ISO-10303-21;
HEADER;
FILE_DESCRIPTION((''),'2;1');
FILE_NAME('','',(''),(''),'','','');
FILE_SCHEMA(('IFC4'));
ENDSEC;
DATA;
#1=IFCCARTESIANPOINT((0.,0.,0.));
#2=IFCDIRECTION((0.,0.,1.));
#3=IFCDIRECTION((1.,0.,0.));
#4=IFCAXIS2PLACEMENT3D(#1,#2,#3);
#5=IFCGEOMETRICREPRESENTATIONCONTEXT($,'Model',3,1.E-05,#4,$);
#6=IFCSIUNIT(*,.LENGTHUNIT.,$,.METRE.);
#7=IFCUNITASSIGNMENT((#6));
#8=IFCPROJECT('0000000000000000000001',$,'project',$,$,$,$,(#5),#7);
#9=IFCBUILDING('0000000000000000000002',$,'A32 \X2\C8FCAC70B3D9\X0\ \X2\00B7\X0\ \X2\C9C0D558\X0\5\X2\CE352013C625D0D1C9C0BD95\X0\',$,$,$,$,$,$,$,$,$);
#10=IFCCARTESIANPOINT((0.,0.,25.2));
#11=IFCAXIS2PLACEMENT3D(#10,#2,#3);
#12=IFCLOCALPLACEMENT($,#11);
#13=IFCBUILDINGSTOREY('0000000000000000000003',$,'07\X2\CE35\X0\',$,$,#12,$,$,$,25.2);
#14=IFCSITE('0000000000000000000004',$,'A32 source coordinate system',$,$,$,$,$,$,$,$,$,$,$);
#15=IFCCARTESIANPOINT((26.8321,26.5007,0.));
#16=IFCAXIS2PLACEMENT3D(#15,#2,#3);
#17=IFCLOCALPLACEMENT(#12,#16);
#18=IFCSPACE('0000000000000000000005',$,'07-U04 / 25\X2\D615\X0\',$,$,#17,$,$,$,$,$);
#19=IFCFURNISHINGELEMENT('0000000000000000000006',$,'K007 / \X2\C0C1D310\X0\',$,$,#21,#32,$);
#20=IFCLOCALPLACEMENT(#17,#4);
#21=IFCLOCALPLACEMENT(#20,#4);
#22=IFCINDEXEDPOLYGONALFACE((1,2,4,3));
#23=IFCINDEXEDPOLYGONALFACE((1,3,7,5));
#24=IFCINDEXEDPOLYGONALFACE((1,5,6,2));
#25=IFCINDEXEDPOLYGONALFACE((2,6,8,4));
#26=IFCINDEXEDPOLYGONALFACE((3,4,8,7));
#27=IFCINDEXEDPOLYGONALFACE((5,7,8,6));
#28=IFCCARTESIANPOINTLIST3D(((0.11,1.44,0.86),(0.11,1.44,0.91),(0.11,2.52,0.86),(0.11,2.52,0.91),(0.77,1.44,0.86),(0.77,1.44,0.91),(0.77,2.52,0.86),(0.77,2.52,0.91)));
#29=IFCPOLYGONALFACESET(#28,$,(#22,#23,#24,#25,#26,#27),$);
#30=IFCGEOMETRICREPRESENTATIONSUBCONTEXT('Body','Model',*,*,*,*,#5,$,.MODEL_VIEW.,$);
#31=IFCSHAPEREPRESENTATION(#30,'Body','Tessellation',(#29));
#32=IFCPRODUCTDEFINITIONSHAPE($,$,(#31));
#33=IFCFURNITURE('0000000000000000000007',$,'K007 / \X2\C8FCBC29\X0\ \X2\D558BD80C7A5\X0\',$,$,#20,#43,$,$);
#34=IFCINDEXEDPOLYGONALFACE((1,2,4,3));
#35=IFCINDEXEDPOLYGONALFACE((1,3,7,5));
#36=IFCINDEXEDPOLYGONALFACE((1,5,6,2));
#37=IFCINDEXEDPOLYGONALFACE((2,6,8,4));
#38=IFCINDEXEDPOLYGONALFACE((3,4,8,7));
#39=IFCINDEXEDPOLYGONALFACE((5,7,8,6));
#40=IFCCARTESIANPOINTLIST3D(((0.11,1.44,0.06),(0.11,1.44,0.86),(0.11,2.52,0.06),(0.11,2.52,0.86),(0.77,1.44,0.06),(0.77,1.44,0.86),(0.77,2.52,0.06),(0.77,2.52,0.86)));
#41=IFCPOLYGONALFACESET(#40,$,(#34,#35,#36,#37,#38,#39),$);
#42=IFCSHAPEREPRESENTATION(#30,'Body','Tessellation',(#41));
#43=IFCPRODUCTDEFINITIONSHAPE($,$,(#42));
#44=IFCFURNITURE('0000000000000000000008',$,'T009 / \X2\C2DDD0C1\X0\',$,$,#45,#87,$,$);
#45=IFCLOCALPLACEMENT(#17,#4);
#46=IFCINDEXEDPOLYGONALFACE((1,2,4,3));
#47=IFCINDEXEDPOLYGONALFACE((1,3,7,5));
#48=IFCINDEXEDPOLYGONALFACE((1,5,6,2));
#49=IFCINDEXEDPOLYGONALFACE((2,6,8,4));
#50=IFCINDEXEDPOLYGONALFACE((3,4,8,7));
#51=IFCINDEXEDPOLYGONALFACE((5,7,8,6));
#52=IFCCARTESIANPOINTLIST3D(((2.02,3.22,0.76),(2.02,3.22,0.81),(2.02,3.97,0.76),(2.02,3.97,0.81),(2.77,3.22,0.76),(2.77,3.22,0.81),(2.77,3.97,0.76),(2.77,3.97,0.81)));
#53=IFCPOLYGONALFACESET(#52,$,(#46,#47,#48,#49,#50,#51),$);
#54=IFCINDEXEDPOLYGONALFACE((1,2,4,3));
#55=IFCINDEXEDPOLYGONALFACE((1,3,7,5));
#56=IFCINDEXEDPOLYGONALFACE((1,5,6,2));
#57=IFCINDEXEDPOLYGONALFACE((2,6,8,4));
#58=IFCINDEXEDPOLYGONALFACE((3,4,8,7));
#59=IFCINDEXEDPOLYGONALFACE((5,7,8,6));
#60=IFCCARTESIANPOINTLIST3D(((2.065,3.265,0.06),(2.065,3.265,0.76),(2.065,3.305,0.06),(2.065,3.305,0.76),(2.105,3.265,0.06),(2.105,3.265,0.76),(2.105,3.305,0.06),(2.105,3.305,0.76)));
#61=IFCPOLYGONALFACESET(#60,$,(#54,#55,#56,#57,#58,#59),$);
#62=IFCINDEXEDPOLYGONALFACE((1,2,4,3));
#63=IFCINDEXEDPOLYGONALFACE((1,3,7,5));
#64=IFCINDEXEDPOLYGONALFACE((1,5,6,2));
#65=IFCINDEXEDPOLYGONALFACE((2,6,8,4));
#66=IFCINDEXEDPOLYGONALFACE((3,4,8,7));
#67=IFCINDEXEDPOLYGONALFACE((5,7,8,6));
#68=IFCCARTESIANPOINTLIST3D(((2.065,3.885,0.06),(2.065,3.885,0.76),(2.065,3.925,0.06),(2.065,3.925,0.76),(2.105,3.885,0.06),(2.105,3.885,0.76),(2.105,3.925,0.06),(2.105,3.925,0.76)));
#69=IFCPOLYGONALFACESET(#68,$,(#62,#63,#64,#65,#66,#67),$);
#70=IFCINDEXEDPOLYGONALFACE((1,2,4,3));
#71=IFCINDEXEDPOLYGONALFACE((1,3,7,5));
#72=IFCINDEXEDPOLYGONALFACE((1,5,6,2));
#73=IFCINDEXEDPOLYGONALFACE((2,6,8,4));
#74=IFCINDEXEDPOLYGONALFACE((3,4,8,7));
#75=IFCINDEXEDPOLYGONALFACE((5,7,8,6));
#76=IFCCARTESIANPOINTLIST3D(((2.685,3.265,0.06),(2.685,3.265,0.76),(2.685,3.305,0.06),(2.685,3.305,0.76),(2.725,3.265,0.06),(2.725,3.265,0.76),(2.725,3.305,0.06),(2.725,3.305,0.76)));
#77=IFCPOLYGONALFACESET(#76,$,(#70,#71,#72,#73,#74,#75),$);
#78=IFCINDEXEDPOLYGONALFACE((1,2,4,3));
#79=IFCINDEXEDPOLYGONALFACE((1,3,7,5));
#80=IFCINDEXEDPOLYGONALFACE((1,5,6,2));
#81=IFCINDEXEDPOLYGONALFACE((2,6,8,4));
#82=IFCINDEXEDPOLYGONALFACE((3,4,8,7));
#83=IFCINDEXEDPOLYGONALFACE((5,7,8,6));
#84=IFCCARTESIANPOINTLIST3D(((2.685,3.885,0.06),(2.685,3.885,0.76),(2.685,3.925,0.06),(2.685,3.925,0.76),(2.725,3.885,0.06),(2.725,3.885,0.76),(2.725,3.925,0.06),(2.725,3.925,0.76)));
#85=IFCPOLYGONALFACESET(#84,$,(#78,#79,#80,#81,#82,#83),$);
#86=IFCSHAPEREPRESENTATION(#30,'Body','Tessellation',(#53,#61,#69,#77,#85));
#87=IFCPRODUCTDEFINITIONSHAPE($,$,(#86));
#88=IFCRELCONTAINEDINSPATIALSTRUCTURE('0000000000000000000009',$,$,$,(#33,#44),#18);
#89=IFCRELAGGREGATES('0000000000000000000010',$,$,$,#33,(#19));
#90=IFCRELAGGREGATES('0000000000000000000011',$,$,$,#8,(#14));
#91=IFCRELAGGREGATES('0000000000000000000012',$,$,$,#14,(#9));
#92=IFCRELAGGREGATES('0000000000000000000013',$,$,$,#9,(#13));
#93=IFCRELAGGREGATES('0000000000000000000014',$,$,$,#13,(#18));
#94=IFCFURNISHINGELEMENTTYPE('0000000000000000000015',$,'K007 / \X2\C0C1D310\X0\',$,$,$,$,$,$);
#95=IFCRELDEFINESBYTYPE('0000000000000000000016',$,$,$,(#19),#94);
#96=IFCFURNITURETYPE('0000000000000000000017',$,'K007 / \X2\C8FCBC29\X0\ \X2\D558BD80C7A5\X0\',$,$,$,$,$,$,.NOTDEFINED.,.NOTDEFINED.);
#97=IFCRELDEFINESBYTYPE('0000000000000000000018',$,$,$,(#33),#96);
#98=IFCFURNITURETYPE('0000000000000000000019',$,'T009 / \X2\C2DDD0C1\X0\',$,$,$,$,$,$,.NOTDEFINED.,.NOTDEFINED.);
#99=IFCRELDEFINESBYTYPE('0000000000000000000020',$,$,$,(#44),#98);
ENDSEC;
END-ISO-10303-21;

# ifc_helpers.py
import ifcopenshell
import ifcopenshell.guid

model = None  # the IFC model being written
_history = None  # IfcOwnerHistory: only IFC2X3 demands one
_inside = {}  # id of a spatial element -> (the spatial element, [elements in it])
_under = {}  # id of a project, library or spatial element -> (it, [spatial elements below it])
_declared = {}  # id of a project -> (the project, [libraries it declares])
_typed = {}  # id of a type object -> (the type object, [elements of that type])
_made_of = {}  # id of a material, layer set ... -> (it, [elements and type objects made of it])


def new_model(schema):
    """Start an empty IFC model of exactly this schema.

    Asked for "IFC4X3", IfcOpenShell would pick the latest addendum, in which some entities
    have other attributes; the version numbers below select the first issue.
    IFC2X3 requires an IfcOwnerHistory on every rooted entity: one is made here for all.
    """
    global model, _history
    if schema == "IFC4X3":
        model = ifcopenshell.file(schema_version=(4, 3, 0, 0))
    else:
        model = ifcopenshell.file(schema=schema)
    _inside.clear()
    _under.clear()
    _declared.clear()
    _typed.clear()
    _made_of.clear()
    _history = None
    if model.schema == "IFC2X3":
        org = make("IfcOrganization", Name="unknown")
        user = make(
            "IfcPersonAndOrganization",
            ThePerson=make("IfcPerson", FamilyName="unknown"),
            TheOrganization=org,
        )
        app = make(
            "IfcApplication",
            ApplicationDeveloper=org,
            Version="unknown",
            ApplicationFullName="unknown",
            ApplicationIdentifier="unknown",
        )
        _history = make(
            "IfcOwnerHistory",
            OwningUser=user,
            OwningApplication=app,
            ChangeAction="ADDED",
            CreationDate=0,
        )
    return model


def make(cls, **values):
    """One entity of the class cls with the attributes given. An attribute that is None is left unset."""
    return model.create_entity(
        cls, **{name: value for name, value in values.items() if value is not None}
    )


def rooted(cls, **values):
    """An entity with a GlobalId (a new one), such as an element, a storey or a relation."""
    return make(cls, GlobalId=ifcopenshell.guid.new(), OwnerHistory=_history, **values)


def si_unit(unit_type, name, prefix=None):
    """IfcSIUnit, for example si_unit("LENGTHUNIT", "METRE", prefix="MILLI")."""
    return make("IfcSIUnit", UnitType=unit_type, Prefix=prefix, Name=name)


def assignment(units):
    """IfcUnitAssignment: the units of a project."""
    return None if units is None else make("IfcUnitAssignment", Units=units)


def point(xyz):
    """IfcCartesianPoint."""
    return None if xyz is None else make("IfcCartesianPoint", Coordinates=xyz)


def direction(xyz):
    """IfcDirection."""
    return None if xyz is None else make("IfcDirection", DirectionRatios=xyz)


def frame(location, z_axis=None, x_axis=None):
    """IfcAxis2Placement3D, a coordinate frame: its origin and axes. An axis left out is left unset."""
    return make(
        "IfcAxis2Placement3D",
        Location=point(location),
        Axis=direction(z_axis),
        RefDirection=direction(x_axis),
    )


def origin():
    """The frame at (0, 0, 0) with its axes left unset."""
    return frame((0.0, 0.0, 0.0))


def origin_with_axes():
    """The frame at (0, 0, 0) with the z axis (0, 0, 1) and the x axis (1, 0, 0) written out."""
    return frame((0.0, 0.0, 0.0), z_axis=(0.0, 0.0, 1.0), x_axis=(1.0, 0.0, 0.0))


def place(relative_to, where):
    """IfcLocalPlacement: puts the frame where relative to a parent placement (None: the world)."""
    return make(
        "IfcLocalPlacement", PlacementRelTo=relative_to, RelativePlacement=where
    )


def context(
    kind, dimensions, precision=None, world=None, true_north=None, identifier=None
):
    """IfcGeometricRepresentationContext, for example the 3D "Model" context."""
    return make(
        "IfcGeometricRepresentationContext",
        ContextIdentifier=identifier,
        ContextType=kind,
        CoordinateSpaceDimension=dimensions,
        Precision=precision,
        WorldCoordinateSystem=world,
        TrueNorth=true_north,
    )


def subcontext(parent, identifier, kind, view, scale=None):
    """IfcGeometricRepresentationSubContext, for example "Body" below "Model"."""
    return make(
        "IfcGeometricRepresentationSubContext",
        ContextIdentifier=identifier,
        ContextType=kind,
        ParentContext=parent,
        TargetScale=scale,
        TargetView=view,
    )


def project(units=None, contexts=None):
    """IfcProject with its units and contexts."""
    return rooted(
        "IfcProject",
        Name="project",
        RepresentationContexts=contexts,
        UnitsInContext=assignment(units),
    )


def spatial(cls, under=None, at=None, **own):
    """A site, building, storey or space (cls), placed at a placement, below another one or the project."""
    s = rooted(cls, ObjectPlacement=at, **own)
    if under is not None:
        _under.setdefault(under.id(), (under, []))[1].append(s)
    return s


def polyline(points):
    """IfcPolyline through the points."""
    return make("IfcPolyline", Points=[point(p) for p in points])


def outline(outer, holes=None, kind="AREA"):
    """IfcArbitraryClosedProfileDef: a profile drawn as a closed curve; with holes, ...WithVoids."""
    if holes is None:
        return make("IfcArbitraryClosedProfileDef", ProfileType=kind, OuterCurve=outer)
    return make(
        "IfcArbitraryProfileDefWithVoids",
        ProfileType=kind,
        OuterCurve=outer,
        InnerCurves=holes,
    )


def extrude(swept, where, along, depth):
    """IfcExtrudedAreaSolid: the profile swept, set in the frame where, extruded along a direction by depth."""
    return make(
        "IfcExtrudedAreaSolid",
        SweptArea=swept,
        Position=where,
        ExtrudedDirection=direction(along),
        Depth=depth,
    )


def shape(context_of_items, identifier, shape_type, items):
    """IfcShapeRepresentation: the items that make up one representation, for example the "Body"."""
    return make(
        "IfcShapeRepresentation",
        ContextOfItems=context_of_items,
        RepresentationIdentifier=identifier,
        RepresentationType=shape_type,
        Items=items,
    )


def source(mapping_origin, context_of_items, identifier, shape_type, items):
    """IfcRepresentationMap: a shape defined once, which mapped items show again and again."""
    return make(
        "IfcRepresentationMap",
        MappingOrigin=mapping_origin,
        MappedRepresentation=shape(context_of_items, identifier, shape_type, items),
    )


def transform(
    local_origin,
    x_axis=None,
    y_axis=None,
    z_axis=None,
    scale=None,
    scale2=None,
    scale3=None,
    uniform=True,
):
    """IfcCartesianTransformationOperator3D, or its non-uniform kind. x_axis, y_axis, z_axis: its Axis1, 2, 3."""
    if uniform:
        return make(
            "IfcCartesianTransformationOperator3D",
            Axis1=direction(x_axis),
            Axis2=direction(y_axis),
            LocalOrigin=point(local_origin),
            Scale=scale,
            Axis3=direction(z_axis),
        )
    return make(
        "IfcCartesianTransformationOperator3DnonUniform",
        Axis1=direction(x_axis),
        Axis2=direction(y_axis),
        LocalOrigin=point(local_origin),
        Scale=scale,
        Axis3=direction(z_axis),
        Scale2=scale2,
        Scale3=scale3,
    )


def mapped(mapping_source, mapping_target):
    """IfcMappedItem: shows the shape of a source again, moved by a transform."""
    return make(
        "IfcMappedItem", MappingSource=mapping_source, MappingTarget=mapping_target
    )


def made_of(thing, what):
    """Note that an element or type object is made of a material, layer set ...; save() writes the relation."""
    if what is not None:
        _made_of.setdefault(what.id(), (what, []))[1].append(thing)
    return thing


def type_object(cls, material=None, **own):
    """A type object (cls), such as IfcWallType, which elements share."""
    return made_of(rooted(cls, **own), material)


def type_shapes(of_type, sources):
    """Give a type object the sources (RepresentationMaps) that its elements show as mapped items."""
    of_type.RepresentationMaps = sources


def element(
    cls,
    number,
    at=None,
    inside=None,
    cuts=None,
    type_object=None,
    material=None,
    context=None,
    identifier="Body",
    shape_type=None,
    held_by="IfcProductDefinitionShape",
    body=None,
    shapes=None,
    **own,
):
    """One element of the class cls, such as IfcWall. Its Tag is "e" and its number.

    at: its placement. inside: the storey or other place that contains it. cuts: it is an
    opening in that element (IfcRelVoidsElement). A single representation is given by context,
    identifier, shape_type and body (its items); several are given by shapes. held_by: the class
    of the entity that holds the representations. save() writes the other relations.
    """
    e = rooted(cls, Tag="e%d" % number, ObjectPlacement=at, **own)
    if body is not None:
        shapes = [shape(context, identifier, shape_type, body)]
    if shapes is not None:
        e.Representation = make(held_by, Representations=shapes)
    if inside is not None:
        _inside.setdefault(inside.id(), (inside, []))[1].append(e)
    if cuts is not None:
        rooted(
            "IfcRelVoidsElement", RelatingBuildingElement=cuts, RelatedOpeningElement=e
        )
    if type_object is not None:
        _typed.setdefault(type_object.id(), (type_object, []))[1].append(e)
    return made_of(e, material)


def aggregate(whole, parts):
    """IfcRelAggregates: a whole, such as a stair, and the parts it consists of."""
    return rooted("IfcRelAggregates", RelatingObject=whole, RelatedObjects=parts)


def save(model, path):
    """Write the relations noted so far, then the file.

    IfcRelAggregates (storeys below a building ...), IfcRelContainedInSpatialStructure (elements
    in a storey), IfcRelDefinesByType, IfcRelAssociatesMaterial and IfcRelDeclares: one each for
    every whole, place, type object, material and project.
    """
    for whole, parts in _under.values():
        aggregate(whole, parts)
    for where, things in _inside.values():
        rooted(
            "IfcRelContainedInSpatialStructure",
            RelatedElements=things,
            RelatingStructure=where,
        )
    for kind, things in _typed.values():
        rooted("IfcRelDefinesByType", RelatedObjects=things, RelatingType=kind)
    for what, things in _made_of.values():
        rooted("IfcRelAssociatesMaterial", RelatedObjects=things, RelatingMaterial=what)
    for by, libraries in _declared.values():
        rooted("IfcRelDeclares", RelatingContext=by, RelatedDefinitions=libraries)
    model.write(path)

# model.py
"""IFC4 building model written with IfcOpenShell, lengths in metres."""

from ifc_helpers import new_model, si_unit, frame, origin, origin_with_axes, place, context, subcontext, project, spatial, polyline, outline, extrude, source, transform, mapped, type_object, type_shapes, element, aggregate, save


model = new_model("IFC4")

# Units and contexts
model_context = context("Model", 3, precision=1e-05, world=origin_with_axes())
body_context = subcontext(model_context, "Body", "Model", "MODEL_VIEW")
ifc_project = project(units=[si_unit("LENGTHUNIT", "METRE")], contexts=[model_context])

# Site, building, storey
site = spatial("IfcSite", under=ifc_project, Name="A32 source coordinate system")
building = spatial("IfcBuilding", under=site, Name="A32 주거동 · 지하5층–옥탑지붕")
storey_placement = place(None, frame((0.0, 0.0, 25.2), z_axis=(0.0, 0.0, 1.0), x_axis=(1.0, 0.0, 0.0)))
storey = spatial("IfcBuildingStorey", under=building, at=storey_placement, Name="07층", Elevation=25.2)

# Shared definitions
space_1_placement = place(storey_placement, frame((26.8321, 26.5007, 0.0), z_axis=(0.0, 0.0, 1.0), x_axis=(1.0, 0.0, 0.0)))
space_1 = spatial("IfcSpace", under=storey, at=space_1_placement, Name="07-U04 / 25형")

# Furnishing element
furnishing_element_type_1 = type_object("IfcFurnishingElementType", Name="K007 / 상판")
shared_shape_1 = source(origin(), body_context, "Body", "SweptSolid", [
    extrude(outline(polyline([(0.77, 2.52), (0.77, 1.44), (0.11, 1.44), (0.11, 2.52), (0.77, 2.52)])), frame((0.0, 0.0, 0.86)), (0.0, 0.0, 1.0), 0.05),
])
type_shapes(furnishing_element_type_1, [shared_shape_1])
furniture_1_placement = place(space_1_placement, origin_with_axes())
furnishing_1_placement = place(furniture_1_placement, origin_with_axes())
furnishing_1 = element("IfcFurnishingElement", 1, at=furnishing_1_placement, type_object=furnishing_element_type_1, Name="K007 / 상판", context=body_context, shape_type="MappedRepresentation", body=[
    mapped(shared_shape_1, transform((0.0, 0.0, 0.0), scale=1.0)),
])

# Furniture
furniture_type_1 = type_object("IfcFurnitureType", Name="K007 / 주방 하부장", AssemblyPlace="NOTDEFINED", PredefinedType="NOTDEFINED")
shared_shape_2 = source(origin(), body_context, "Body", "SweptSolid", [
    extrude(outline(polyline([(0.11, 2.52), (0.77, 2.52), (0.77, 1.44), (0.11, 1.44), (0.11, 2.52)])), frame((0.0, 0.0, 0.06)), (0.0, 0.0, 1.0), 0.8),
])
type_shapes(furniture_type_1, [shared_shape_2])
furniture_1 = element("IfcFurniture", 2, at=furniture_1_placement, inside=space_1, type_object=furniture_type_1, Name="K007 / 주방 하부장", context=body_context, shape_type="MappedRepresentation", body=[
    mapped(shared_shape_2, transform((0.0, 0.0, 0.0), scale=1.0)),
])
aggregate(furniture_1, [furnishing_1])
furniture_type_2 = type_object("IfcFurnitureType", Name="T009 / 식탁", AssemblyPlace="NOTDEFINED", PredefinedType="NOTDEFINED")
shared_shape_3 = source(origin(), body_context, "Body", "SweptSolid", [
    extrude(outline(polyline([(2.77, 3.22), (2.02, 3.22), (2.02, 3.97), (2.77, 3.97), (2.77, 3.22)])), frame((0.0, 0.0, 0.76)), (0.0, 0.0, 1.0), 0.05),
    extrude(outline(polyline([(2.065, 3.265), (2.065, 3.305), (2.105, 3.305), (2.105, 3.265), (2.065, 3.265)])), frame((0.0, 0.0, 0.06)), (0.0, 0.0, 1.0), 0.7),
    extrude(outline(polyline([(2.065, 3.885), (2.065, 3.925), (2.105, 3.925), (2.105, 3.885), (2.065, 3.885)])), frame((0.0, 0.0, 0.06)), (0.0, 0.0, 1.0), 0.7),
    extrude(outline(polyline([(2.685, 3.265), (2.685, 3.305), (2.725, 3.305), (2.725, 3.265), (2.685, 3.265)])), frame((0.0, 0.0, 0.06)), (0.0, 0.0, 1.0), 0.7),
    extrude(outline(polyline([(2.685, 3.885), (2.685, 3.925), (2.725, 3.925), (2.725, 3.885), (2.685, 3.885)])), frame((0.0, 0.0, 0.06)), (0.0, 0.0, 1.0), 0.7),
])
type_shapes(furniture_type_2, [shared_shape_3])
furniture_2_placement = place(space_1_placement, origin_with_axes())
element("IfcFurniture", 3, at=furniture_2_placement, inside=space_1, type_object=furniture_type_2, Name="T009 / 식탁", context=body_context, shape_type="MappedRepresentation", body=[
    mapped(shared_shape_3, transform((0.0, 0.0, 0.0), scale=1.0)),
])

save(model, "model.ifc")
